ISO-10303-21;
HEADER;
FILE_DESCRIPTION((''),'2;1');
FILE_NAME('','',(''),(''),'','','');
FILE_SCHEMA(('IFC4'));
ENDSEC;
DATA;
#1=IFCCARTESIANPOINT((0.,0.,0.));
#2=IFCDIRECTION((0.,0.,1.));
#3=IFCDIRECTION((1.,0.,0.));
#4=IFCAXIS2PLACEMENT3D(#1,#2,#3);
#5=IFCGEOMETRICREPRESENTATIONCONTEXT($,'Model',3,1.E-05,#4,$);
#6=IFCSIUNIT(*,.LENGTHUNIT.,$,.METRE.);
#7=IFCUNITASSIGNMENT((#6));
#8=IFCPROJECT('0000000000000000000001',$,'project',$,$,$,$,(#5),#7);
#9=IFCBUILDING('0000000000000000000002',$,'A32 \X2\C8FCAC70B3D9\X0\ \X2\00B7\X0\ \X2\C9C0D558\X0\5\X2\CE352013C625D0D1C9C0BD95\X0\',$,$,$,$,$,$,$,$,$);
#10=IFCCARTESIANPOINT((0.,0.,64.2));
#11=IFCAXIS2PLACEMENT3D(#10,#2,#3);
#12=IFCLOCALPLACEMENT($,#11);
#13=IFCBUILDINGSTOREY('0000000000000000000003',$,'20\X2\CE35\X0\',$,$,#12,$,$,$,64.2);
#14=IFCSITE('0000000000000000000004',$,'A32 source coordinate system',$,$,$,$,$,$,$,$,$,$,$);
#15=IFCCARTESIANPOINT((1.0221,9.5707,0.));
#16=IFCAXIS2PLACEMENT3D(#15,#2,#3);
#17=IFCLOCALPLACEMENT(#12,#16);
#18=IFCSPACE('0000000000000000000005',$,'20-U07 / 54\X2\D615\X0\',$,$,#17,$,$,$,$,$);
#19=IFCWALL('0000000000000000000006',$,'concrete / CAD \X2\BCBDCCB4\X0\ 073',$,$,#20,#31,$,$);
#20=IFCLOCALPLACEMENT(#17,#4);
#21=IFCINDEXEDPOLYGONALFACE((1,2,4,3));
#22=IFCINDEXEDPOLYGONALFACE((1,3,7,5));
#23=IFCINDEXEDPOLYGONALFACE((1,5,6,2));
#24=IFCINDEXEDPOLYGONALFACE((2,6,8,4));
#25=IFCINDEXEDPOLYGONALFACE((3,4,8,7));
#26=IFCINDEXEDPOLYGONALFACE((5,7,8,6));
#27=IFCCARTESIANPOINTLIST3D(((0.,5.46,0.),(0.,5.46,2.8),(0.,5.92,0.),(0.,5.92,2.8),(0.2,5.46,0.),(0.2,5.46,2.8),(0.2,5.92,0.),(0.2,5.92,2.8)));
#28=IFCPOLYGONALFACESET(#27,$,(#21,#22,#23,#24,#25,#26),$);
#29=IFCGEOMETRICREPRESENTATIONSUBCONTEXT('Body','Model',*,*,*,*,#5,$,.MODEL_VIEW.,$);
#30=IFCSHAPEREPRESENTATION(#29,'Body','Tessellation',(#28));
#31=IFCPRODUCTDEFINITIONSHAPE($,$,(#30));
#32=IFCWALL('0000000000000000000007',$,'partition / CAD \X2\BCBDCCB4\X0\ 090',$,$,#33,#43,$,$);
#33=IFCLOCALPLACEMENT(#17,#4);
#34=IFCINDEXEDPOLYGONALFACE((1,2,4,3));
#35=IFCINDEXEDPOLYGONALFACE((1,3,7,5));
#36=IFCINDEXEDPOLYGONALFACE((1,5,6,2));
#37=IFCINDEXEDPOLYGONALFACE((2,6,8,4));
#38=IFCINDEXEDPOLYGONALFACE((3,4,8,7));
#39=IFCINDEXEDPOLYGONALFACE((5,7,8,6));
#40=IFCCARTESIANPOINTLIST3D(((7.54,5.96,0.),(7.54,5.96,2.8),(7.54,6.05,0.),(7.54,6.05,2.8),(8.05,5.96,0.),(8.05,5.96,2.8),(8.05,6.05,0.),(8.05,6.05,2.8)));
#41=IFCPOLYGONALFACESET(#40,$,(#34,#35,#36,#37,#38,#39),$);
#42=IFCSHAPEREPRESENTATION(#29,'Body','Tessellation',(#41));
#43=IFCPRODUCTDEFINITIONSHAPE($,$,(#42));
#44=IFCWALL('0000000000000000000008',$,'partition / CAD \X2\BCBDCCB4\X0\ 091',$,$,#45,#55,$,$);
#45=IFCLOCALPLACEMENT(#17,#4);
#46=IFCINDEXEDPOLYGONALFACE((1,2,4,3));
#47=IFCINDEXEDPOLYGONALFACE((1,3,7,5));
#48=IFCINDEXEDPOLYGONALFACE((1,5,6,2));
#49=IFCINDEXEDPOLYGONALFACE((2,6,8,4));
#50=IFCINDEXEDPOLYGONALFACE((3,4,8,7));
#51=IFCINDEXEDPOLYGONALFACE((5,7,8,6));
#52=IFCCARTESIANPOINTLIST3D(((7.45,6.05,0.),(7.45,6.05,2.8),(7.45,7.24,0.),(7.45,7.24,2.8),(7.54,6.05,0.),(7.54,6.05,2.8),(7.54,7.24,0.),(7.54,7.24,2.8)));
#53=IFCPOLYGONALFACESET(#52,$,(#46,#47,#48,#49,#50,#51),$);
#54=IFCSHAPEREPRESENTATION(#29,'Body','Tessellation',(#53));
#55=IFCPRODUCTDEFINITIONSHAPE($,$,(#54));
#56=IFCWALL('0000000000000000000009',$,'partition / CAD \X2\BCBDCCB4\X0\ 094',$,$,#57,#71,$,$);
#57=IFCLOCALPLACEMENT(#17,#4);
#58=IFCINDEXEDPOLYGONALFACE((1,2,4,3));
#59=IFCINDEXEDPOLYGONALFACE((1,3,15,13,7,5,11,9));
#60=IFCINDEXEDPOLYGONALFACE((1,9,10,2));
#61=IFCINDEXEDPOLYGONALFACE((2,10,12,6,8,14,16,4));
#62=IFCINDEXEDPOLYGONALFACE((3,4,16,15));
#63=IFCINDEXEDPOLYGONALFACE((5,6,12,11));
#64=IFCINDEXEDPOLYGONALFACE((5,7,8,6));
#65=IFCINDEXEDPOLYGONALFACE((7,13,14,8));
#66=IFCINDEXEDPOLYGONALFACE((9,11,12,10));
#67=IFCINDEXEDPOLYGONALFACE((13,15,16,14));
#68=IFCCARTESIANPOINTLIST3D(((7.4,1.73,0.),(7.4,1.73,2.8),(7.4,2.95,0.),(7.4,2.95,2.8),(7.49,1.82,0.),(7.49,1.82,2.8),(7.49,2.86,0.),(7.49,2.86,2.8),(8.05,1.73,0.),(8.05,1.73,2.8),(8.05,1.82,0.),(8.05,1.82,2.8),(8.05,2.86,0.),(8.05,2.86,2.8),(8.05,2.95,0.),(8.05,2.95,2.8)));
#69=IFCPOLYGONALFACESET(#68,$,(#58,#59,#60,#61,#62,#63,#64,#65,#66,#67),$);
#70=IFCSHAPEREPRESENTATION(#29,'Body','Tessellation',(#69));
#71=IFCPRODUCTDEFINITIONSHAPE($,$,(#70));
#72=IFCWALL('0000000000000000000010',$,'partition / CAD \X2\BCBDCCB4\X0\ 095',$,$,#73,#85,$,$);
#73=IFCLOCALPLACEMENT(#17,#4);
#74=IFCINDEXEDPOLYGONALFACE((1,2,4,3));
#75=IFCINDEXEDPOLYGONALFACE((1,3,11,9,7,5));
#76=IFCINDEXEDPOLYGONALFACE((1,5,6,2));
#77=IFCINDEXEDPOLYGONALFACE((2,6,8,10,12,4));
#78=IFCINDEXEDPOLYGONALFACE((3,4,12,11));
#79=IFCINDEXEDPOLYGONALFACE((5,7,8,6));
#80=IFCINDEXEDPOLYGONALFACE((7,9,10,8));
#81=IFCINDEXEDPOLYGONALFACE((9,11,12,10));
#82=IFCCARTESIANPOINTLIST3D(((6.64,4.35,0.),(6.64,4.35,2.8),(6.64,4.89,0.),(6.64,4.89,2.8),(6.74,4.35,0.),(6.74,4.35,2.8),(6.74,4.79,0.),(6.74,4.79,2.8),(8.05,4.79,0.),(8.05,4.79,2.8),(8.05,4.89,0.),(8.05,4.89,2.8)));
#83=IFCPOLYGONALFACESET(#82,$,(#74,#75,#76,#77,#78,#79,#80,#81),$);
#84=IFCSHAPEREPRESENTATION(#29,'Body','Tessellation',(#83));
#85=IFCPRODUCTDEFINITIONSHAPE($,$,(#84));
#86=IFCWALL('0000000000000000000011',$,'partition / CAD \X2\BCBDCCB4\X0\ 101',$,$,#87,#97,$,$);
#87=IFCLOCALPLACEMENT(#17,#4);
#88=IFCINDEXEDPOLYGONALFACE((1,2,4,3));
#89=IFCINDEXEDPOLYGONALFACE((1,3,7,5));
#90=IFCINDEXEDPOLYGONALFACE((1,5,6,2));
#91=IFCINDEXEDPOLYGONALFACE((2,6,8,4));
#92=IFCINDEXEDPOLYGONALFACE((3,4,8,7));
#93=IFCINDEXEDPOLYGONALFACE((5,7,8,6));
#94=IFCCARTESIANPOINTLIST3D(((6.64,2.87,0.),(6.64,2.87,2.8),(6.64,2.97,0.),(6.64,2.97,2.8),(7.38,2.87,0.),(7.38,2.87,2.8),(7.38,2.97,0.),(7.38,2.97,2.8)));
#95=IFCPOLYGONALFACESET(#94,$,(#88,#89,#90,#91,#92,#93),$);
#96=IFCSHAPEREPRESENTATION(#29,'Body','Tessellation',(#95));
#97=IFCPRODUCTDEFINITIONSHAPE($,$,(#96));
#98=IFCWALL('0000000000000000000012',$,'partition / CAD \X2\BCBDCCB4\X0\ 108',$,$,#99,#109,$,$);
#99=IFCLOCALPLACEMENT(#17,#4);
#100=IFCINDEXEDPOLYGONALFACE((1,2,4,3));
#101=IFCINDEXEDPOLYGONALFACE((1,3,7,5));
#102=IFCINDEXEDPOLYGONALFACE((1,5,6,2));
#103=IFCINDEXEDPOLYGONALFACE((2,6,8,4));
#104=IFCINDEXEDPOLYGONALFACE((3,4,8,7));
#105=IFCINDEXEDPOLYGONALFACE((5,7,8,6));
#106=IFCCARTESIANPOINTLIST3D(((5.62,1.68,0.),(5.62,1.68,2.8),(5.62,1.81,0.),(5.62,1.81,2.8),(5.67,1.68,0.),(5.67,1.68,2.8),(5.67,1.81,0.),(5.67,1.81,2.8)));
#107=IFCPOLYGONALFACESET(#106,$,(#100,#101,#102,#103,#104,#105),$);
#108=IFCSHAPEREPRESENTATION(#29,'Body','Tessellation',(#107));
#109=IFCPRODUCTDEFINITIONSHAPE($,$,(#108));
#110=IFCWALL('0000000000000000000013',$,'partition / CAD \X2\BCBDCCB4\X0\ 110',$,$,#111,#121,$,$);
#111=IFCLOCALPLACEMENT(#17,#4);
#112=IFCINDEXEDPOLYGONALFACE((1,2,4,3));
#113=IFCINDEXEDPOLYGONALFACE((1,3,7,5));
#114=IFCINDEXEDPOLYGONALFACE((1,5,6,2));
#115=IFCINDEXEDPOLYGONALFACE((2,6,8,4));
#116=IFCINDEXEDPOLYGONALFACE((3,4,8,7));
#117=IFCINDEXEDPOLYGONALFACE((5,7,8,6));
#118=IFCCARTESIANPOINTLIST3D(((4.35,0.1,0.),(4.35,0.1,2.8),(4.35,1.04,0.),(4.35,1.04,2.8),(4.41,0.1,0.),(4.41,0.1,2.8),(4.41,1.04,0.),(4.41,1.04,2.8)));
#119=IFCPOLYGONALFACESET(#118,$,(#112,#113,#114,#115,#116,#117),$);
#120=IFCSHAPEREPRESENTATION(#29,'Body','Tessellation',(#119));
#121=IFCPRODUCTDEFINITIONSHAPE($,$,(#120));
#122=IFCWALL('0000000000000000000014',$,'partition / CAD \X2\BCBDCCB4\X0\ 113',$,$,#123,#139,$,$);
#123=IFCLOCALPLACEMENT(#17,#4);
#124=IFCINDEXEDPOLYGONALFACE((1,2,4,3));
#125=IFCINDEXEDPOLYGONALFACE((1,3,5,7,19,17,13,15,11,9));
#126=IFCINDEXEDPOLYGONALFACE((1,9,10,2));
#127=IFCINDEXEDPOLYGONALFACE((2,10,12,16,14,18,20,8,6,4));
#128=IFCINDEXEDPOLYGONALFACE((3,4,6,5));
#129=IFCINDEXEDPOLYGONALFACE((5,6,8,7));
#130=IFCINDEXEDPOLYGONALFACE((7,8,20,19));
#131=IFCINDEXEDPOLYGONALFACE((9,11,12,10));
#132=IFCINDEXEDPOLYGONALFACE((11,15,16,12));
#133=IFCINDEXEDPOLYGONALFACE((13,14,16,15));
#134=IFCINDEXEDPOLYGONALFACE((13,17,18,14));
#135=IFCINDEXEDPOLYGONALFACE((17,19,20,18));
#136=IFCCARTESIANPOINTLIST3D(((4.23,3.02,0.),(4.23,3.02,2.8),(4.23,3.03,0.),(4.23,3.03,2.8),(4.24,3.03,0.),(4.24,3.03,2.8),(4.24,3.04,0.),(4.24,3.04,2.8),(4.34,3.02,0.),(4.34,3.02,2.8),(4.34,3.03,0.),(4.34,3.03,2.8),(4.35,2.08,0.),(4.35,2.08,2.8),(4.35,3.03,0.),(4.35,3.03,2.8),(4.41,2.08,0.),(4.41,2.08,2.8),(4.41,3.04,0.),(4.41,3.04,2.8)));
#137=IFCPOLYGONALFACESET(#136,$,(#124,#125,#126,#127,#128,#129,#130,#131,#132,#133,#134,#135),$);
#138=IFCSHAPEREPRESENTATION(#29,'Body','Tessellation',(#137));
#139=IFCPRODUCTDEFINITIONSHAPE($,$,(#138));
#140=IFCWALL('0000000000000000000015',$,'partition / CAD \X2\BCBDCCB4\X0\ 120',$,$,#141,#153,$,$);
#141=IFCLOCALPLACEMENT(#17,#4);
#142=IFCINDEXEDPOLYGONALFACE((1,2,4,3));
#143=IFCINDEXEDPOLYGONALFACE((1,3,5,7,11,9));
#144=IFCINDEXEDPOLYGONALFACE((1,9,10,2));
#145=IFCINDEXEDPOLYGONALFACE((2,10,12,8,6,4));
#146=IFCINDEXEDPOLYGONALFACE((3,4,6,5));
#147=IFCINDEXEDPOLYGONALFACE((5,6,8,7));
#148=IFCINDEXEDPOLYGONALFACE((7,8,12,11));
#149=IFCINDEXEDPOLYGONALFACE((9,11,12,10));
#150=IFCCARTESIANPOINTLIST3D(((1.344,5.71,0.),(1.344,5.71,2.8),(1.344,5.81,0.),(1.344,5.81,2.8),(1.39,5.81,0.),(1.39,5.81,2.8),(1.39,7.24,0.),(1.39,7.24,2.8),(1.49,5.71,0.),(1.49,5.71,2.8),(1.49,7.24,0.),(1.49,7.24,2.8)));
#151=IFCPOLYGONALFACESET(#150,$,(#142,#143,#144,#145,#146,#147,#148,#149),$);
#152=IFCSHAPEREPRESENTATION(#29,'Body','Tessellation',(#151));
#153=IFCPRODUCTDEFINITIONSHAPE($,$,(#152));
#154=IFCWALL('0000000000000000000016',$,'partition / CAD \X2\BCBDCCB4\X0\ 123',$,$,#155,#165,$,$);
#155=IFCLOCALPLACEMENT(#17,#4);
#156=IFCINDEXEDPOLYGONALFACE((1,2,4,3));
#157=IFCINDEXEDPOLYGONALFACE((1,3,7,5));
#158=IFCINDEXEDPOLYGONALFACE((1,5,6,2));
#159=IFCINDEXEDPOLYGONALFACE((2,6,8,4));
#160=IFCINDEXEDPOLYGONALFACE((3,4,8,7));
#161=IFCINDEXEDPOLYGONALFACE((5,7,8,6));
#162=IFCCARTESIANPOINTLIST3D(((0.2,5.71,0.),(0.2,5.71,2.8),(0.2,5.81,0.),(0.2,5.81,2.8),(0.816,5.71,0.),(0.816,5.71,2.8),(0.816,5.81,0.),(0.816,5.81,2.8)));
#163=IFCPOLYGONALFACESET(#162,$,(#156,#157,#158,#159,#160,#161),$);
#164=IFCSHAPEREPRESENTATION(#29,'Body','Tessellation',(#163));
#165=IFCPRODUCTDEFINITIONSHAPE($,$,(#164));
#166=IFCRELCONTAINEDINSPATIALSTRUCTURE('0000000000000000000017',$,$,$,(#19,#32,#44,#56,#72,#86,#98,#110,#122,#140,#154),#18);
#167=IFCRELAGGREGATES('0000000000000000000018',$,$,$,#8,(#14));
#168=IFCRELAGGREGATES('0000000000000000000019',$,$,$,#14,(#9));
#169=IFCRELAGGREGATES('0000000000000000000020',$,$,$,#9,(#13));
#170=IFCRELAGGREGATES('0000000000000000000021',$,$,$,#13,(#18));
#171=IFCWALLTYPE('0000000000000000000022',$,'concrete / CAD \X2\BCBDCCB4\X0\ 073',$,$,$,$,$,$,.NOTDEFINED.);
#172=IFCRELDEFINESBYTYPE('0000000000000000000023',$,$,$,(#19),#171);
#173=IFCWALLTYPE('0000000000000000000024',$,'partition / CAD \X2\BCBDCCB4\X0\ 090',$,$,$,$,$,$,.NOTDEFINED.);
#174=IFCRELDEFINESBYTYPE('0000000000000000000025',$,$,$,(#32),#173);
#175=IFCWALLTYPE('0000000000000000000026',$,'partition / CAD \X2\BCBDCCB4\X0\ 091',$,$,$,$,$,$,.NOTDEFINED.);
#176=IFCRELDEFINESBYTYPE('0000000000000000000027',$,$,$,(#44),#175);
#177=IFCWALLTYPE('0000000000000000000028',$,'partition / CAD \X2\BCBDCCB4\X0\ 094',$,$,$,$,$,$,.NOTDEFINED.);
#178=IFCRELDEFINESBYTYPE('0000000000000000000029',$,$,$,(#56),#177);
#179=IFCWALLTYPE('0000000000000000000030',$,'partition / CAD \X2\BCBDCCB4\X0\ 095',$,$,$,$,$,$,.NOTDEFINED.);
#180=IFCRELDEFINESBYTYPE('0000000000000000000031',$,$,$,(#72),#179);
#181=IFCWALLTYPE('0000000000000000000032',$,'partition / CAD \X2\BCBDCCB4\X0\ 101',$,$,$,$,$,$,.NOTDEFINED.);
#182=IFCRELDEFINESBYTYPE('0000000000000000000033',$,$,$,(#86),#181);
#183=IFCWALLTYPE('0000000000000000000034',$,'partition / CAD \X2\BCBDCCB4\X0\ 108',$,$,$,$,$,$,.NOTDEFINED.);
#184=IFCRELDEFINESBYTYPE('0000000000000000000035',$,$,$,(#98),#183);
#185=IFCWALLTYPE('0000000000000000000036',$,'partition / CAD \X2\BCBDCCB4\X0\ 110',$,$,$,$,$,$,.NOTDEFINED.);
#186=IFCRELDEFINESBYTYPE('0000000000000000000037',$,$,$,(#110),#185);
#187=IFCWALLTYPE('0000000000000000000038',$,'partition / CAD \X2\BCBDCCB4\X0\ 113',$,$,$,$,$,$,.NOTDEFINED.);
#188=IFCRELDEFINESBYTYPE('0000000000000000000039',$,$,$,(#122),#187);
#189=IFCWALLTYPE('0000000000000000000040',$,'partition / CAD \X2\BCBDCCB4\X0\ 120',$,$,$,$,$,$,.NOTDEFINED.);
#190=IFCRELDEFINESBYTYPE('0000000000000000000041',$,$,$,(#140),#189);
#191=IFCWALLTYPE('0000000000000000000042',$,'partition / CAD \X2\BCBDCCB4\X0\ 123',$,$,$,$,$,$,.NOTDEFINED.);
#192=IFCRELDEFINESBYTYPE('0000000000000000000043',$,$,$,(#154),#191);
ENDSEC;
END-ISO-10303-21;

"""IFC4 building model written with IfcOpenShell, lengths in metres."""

from ifc_helpers import new_model, si_unit, frame, origin, origin_with_axes, place, context, subcontext, project, spatial, polyline, outline, extrude, source, transform, mapped, type_object, type_shapes, element, save


model = new_model("IFC4")

# Units and contexts
model_context = context("Model", 3, precision=1e-05, world=origin_with_axes())
body_context = subcontext(model_context, "Body", "Model", "MODEL_VIEW")
ifc_project = project(units=[si_unit("LENGTHUNIT", "METRE")], contexts=[model_context])

# Site, building, storey, space
site = spatial("IfcSite", under=ifc_project, Name="A32 source coordinate system")
building = spatial("IfcBuilding", under=site, Name="A32 주거동 · 지하5층–옥탑지붕")
storey_placement = place(None, frame((0.0, 0.0, 64.2), z_axis=(0.0, 0.0, 1.0), x_axis=(1.0, 0.0, 0.0)))
storey = spatial("IfcBuildingStorey", under=building, at=storey_placement, Name="20층", Elevation=64.2)
space_1_placement = place(storey_placement, frame((1.0221, 9.5707, 0.0), z_axis=(0.0, 0.0, 1.0), x_axis=(1.0, 0.0, 0.0)))
space_1 = spatial("IfcSpace", under=storey, at=space_1_placement, Name="20-U07 / 54형")

# Walls
wall_type_1 = type_object("IfcWallType", Name="concrete / CAD 벽체 073", PredefinedType="NOTDEFINED")
shared_shape_1 = source(origin(), body_context, "Body", "SweptSolid", [
    extrude(outline(polyline([(0.2, 5.92), (0.2, 5.46), (0.0, 5.46), (0.0, 5.92), (0.2, 5.92)])), origin(), (0.0, 0.0, 1.0), 2.8),
])
type_shapes(wall_type_1, [shared_shape_1])
wall_1_placement = place(space_1_placement, origin_with_axes())
element("IfcWall", 1, at=wall_1_placement, inside=space_1, type_object=wall_type_1, Name="concrete / CAD 벽체 073", context=body_context, shape_type="MappedRepresentation", body=[
    mapped(shared_shape_1, transform((0.0, 0.0, 0.0), scale=1.0)),
])
wall_type_2 = type_object("IfcWallType", Name="partition / CAD 벽체 090", PredefinedType="NOTDEFINED")
shared_shape_2 = source(origin(), body_context, "Body", "SweptSolid", [
    extrude(outline(polyline([(7.54, 5.96), (7.54, 6.05), (8.05, 6.05), (8.05, 5.96), (7.54, 5.96)])), origin(), (0.0, 0.0, 1.0), 2.8),
])
type_shapes(wall_type_2, [shared_shape_2])
wall_2_placement = place(space_1_placement, origin_with_axes())
element("IfcWall", 2, at=wall_2_placement, inside=space_1, type_object=wall_type_2, Name="partition / CAD 벽체 090", context=body_context, shape_type="MappedRepresentation", body=[
    mapped(shared_shape_2, transform((0.0, 0.0, 0.0), scale=1.0)),
])
wall_type_3 = type_object("IfcWallType", Name="partition / CAD 벽체 091", PredefinedType="NOTDEFINED")
shared_shape_3 = source(origin(), body_context, "Body", "SweptSolid", [
    extrude(outline(polyline([(7.54, 6.05), (7.45, 6.05), (7.45, 7.24), (7.54, 7.24), (7.54, 6.05)])), origin(), (0.0, 0.0, 1.0), 2.8),
])
type_shapes(wall_type_3, [shared_shape_3])
wall_3_placement = place(space_1_placement, origin_with_axes())
element("IfcWall", 3, at=wall_3_placement, inside=space_1, type_object=wall_type_3, Name="partition / CAD 벽체 091", context=body_context, shape_type="MappedRepresentation", body=[
    mapped(shared_shape_3, transform((0.0, 0.0, 0.0), scale=1.0)),
])
wall_type_4 = type_object("IfcWallType", Name="partition / CAD 벽체 094", PredefinedType="NOTDEFINED")
shared_shape_4 = source(origin(), body_context, "Body", "SweptSolid", [
    extrude(outline(polyline([(8.05, 1.73), (7.4, 1.73), (7.4, 2.95), (8.05, 2.95), (8.05, 2.86), (7.49, 2.86), (7.49, 1.82), (8.05, 1.82), (8.05, 1.73)])), origin(), (0.0, 0.0, 1.0), 2.8),
])
type_shapes(wall_type_4, [shared_shape_4])
wall_4_placement = place(space_1_placement, origin_with_axes())
element("IfcWall", 4, at=wall_4_placement, inside=space_1, type_object=wall_type_4, Name="partition / CAD 벽체 094", context=body_context, shape_type="MappedRepresentation", body=[
    mapped(shared_shape_4, transform((0.0, 0.0, 0.0), scale=1.0)),
])
wall_type_5 = type_object("IfcWallType", Name="partition / CAD 벽체 095", PredefinedType="NOTDEFINED")
shared_shape_5 = source(origin(), body_context, "Body", "SweptSolid", [
    extrude(outline(polyline([(6.64, 4.89), (8.05, 4.89), (8.05, 4.79), (6.74, 4.79), (6.74, 4.35), (6.64, 4.35), (6.64, 4.89)])), origin(), (0.0, 0.0, 1.0), 2.8),
])
type_shapes(wall_type_5, [shared_shape_5])
wall_5_placement = place(space_1_placement, origin_with_axes())
element("IfcWall", 5, at=wall_5_placement, inside=space_1, type_object=wall_type_5, Name="partition / CAD 벽체 095", context=body_context, shape_type="MappedRepresentation", body=[
    mapped(shared_shape_5, transform((0.0, 0.0, 0.0), scale=1.0)),
])
wall_type_6 = type_object("IfcWallType", Name="partition / CAD 벽체 101", PredefinedType="NOTDEFINED")
shared_shape_6 = source(origin(), body_context, "Body", "SweptSolid", [
    extrude(outline(polyline([(7.38, 2.97), (7.38, 2.87), (6.64, 2.87), (6.64, 2.97), (7.38, 2.97)])), origin(), (0.0, 0.0, 1.0), 2.8),
])
type_shapes(wall_type_6, [shared_shape_6])
wall_6_placement = place(space_1_placement, origin_with_axes())
element("IfcWall", 6, at=wall_6_placement, inside=space_1, type_object=wall_type_6, Name="partition / CAD 벽체 101", context=body_context, shape_type="MappedRepresentation", body=[
    mapped(shared_shape_6, transform((0.0, 0.0, 0.0), scale=1.0)),
])
wall_type_7 = type_object("IfcWallType", Name="partition / CAD 벽체 108", PredefinedType="NOTDEFINED")
shared_shape_7 = source(origin(), body_context, "Body", "SweptSolid", [
    extrude(outline(polyline([(5.67, 1.68), (5.62, 1.68), (5.62, 1.81), (5.67, 1.81), (5.67, 1.68)])), origin(), (0.0, 0.0, 1.0), 2.8),
])
type_shapes(wall_type_7, [shared_shape_7])
wall_7_placement = place(space_1_placement, origin_with_axes())
element("IfcWall", 7, at=wall_7_placement, inside=space_1, type_object=wall_type_7, Name="partition / CAD 벽체 108", context=body_context, shape_type="MappedRepresentation", body=[
    mapped(shared_shape_7, transform((0.0, 0.0, 0.0), scale=1.0)),
])
wall_type_8 = type_object("IfcWallType", Name="partition / CAD 벽체 110", PredefinedType="NOTDEFINED")
shared_shape_8 = source(origin(), body_context, "Body", "SweptSolid", [
    extrude(outline(polyline([(4.35, 1.04), (4.41, 1.04), (4.41, 0.1), (4.35, 0.1), (4.35, 1.04)])), origin(), (0.0, 0.0, 1.0), 2.8),
])
type_shapes(wall_type_8, [shared_shape_8])
wall_8_placement = place(space_1_placement, origin_with_axes())
element("IfcWall", 8, at=wall_8_placement, inside=space_1, type_object=wall_type_8, Name="partition / CAD 벽체 110", context=body_context, shape_type="MappedRepresentation", body=[
    mapped(shared_shape_8, transform((0.0, 0.0, 0.0), scale=1.0)),
])
wall_type_9 = type_object("IfcWallType", Name="partition / CAD 벽체 113", PredefinedType="NOTDEFINED")
shared_shape_9 = source(origin(), body_context, "Body", "SweptSolid", [
    extrude(outline(polyline([(4.24, 3.04), (4.41, 3.04), (4.41, 2.08), (4.35, 2.08), (4.35, 3.03), (4.34, 3.03), (4.34, 3.02), (4.23, 3.02), (4.23, 3.03), (4.24, 3.03), (4.24, 3.04)])), origin(), (0.0, 0.0, 1.0), 2.8),
])
type_shapes(wall_type_9, [shared_shape_9])
wall_9_placement = place(space_1_placement, origin_with_axes())
element("IfcWall", 9, at=wall_9_placement, inside=space_1, type_object=wall_type_9, Name="partition / CAD 벽체 113", context=body_context, shape_type="MappedRepresentation", body=[
    mapped(shared_shape_9, transform((0.0, 0.0, 0.0), scale=1.0)),
])
wall_type_10 = type_object("IfcWallType", Name="partition / CAD 벽체 120", PredefinedType="NOTDEFINED")
shared_shape_10 = source(origin(), body_context, "Body", "SweptSolid", [
    extrude(outline(polyline([(1.39, 7.24), (1.49, 7.24), (1.49, 5.71), (1.344, 5.71), (1.344, 5.81), (1.39, 5.81), (1.39, 7.24)])), origin(), (0.0, 0.0, 1.0), 2.8),
])
type_shapes(wall_type_10, [shared_shape_10])
wall_10_placement = place(space_1_placement, origin_with_axes())
element("IfcWall", 10, at=wall_10_placement, inside=space_1, type_object=wall_type_10, Name="partition / CAD 벽체 120", context=body_context, shape_type="MappedRepresentation", body=[
    mapped(shared_shape_10, transform((0.0, 0.0, 0.0), scale=1.0)),
])
wall_type_11 = type_object("IfcWallType", Name="partition / CAD 벽체 123", PredefinedType="NOTDEFINED")
shared_shape_11 = source(origin(), body_context, "Body", "SweptSolid", [
    extrude(outline(polyline([(0.816, 5.81), (0.816, 5.71), (0.2, 5.71), (0.2, 5.81), (0.816, 5.81)])), origin(), (0.0, 0.0, 1.0), 2.8),
])
type_shapes(wall_type_11, [shared_shape_11])
wall_11_placement = place(space_1_placement, origin_with_axes())
element("IfcWall", 11, at=wall_11_placement, inside=space_1, type_object=wall_type_11, Name="partition / CAD 벽체 123", context=body_context, shape_type="MappedRepresentation", body=[
    mapped(shared_shape_11, transform((0.0, 0.0, 0.0), scale=1.0)),
])

save(model, "model.ifc")
